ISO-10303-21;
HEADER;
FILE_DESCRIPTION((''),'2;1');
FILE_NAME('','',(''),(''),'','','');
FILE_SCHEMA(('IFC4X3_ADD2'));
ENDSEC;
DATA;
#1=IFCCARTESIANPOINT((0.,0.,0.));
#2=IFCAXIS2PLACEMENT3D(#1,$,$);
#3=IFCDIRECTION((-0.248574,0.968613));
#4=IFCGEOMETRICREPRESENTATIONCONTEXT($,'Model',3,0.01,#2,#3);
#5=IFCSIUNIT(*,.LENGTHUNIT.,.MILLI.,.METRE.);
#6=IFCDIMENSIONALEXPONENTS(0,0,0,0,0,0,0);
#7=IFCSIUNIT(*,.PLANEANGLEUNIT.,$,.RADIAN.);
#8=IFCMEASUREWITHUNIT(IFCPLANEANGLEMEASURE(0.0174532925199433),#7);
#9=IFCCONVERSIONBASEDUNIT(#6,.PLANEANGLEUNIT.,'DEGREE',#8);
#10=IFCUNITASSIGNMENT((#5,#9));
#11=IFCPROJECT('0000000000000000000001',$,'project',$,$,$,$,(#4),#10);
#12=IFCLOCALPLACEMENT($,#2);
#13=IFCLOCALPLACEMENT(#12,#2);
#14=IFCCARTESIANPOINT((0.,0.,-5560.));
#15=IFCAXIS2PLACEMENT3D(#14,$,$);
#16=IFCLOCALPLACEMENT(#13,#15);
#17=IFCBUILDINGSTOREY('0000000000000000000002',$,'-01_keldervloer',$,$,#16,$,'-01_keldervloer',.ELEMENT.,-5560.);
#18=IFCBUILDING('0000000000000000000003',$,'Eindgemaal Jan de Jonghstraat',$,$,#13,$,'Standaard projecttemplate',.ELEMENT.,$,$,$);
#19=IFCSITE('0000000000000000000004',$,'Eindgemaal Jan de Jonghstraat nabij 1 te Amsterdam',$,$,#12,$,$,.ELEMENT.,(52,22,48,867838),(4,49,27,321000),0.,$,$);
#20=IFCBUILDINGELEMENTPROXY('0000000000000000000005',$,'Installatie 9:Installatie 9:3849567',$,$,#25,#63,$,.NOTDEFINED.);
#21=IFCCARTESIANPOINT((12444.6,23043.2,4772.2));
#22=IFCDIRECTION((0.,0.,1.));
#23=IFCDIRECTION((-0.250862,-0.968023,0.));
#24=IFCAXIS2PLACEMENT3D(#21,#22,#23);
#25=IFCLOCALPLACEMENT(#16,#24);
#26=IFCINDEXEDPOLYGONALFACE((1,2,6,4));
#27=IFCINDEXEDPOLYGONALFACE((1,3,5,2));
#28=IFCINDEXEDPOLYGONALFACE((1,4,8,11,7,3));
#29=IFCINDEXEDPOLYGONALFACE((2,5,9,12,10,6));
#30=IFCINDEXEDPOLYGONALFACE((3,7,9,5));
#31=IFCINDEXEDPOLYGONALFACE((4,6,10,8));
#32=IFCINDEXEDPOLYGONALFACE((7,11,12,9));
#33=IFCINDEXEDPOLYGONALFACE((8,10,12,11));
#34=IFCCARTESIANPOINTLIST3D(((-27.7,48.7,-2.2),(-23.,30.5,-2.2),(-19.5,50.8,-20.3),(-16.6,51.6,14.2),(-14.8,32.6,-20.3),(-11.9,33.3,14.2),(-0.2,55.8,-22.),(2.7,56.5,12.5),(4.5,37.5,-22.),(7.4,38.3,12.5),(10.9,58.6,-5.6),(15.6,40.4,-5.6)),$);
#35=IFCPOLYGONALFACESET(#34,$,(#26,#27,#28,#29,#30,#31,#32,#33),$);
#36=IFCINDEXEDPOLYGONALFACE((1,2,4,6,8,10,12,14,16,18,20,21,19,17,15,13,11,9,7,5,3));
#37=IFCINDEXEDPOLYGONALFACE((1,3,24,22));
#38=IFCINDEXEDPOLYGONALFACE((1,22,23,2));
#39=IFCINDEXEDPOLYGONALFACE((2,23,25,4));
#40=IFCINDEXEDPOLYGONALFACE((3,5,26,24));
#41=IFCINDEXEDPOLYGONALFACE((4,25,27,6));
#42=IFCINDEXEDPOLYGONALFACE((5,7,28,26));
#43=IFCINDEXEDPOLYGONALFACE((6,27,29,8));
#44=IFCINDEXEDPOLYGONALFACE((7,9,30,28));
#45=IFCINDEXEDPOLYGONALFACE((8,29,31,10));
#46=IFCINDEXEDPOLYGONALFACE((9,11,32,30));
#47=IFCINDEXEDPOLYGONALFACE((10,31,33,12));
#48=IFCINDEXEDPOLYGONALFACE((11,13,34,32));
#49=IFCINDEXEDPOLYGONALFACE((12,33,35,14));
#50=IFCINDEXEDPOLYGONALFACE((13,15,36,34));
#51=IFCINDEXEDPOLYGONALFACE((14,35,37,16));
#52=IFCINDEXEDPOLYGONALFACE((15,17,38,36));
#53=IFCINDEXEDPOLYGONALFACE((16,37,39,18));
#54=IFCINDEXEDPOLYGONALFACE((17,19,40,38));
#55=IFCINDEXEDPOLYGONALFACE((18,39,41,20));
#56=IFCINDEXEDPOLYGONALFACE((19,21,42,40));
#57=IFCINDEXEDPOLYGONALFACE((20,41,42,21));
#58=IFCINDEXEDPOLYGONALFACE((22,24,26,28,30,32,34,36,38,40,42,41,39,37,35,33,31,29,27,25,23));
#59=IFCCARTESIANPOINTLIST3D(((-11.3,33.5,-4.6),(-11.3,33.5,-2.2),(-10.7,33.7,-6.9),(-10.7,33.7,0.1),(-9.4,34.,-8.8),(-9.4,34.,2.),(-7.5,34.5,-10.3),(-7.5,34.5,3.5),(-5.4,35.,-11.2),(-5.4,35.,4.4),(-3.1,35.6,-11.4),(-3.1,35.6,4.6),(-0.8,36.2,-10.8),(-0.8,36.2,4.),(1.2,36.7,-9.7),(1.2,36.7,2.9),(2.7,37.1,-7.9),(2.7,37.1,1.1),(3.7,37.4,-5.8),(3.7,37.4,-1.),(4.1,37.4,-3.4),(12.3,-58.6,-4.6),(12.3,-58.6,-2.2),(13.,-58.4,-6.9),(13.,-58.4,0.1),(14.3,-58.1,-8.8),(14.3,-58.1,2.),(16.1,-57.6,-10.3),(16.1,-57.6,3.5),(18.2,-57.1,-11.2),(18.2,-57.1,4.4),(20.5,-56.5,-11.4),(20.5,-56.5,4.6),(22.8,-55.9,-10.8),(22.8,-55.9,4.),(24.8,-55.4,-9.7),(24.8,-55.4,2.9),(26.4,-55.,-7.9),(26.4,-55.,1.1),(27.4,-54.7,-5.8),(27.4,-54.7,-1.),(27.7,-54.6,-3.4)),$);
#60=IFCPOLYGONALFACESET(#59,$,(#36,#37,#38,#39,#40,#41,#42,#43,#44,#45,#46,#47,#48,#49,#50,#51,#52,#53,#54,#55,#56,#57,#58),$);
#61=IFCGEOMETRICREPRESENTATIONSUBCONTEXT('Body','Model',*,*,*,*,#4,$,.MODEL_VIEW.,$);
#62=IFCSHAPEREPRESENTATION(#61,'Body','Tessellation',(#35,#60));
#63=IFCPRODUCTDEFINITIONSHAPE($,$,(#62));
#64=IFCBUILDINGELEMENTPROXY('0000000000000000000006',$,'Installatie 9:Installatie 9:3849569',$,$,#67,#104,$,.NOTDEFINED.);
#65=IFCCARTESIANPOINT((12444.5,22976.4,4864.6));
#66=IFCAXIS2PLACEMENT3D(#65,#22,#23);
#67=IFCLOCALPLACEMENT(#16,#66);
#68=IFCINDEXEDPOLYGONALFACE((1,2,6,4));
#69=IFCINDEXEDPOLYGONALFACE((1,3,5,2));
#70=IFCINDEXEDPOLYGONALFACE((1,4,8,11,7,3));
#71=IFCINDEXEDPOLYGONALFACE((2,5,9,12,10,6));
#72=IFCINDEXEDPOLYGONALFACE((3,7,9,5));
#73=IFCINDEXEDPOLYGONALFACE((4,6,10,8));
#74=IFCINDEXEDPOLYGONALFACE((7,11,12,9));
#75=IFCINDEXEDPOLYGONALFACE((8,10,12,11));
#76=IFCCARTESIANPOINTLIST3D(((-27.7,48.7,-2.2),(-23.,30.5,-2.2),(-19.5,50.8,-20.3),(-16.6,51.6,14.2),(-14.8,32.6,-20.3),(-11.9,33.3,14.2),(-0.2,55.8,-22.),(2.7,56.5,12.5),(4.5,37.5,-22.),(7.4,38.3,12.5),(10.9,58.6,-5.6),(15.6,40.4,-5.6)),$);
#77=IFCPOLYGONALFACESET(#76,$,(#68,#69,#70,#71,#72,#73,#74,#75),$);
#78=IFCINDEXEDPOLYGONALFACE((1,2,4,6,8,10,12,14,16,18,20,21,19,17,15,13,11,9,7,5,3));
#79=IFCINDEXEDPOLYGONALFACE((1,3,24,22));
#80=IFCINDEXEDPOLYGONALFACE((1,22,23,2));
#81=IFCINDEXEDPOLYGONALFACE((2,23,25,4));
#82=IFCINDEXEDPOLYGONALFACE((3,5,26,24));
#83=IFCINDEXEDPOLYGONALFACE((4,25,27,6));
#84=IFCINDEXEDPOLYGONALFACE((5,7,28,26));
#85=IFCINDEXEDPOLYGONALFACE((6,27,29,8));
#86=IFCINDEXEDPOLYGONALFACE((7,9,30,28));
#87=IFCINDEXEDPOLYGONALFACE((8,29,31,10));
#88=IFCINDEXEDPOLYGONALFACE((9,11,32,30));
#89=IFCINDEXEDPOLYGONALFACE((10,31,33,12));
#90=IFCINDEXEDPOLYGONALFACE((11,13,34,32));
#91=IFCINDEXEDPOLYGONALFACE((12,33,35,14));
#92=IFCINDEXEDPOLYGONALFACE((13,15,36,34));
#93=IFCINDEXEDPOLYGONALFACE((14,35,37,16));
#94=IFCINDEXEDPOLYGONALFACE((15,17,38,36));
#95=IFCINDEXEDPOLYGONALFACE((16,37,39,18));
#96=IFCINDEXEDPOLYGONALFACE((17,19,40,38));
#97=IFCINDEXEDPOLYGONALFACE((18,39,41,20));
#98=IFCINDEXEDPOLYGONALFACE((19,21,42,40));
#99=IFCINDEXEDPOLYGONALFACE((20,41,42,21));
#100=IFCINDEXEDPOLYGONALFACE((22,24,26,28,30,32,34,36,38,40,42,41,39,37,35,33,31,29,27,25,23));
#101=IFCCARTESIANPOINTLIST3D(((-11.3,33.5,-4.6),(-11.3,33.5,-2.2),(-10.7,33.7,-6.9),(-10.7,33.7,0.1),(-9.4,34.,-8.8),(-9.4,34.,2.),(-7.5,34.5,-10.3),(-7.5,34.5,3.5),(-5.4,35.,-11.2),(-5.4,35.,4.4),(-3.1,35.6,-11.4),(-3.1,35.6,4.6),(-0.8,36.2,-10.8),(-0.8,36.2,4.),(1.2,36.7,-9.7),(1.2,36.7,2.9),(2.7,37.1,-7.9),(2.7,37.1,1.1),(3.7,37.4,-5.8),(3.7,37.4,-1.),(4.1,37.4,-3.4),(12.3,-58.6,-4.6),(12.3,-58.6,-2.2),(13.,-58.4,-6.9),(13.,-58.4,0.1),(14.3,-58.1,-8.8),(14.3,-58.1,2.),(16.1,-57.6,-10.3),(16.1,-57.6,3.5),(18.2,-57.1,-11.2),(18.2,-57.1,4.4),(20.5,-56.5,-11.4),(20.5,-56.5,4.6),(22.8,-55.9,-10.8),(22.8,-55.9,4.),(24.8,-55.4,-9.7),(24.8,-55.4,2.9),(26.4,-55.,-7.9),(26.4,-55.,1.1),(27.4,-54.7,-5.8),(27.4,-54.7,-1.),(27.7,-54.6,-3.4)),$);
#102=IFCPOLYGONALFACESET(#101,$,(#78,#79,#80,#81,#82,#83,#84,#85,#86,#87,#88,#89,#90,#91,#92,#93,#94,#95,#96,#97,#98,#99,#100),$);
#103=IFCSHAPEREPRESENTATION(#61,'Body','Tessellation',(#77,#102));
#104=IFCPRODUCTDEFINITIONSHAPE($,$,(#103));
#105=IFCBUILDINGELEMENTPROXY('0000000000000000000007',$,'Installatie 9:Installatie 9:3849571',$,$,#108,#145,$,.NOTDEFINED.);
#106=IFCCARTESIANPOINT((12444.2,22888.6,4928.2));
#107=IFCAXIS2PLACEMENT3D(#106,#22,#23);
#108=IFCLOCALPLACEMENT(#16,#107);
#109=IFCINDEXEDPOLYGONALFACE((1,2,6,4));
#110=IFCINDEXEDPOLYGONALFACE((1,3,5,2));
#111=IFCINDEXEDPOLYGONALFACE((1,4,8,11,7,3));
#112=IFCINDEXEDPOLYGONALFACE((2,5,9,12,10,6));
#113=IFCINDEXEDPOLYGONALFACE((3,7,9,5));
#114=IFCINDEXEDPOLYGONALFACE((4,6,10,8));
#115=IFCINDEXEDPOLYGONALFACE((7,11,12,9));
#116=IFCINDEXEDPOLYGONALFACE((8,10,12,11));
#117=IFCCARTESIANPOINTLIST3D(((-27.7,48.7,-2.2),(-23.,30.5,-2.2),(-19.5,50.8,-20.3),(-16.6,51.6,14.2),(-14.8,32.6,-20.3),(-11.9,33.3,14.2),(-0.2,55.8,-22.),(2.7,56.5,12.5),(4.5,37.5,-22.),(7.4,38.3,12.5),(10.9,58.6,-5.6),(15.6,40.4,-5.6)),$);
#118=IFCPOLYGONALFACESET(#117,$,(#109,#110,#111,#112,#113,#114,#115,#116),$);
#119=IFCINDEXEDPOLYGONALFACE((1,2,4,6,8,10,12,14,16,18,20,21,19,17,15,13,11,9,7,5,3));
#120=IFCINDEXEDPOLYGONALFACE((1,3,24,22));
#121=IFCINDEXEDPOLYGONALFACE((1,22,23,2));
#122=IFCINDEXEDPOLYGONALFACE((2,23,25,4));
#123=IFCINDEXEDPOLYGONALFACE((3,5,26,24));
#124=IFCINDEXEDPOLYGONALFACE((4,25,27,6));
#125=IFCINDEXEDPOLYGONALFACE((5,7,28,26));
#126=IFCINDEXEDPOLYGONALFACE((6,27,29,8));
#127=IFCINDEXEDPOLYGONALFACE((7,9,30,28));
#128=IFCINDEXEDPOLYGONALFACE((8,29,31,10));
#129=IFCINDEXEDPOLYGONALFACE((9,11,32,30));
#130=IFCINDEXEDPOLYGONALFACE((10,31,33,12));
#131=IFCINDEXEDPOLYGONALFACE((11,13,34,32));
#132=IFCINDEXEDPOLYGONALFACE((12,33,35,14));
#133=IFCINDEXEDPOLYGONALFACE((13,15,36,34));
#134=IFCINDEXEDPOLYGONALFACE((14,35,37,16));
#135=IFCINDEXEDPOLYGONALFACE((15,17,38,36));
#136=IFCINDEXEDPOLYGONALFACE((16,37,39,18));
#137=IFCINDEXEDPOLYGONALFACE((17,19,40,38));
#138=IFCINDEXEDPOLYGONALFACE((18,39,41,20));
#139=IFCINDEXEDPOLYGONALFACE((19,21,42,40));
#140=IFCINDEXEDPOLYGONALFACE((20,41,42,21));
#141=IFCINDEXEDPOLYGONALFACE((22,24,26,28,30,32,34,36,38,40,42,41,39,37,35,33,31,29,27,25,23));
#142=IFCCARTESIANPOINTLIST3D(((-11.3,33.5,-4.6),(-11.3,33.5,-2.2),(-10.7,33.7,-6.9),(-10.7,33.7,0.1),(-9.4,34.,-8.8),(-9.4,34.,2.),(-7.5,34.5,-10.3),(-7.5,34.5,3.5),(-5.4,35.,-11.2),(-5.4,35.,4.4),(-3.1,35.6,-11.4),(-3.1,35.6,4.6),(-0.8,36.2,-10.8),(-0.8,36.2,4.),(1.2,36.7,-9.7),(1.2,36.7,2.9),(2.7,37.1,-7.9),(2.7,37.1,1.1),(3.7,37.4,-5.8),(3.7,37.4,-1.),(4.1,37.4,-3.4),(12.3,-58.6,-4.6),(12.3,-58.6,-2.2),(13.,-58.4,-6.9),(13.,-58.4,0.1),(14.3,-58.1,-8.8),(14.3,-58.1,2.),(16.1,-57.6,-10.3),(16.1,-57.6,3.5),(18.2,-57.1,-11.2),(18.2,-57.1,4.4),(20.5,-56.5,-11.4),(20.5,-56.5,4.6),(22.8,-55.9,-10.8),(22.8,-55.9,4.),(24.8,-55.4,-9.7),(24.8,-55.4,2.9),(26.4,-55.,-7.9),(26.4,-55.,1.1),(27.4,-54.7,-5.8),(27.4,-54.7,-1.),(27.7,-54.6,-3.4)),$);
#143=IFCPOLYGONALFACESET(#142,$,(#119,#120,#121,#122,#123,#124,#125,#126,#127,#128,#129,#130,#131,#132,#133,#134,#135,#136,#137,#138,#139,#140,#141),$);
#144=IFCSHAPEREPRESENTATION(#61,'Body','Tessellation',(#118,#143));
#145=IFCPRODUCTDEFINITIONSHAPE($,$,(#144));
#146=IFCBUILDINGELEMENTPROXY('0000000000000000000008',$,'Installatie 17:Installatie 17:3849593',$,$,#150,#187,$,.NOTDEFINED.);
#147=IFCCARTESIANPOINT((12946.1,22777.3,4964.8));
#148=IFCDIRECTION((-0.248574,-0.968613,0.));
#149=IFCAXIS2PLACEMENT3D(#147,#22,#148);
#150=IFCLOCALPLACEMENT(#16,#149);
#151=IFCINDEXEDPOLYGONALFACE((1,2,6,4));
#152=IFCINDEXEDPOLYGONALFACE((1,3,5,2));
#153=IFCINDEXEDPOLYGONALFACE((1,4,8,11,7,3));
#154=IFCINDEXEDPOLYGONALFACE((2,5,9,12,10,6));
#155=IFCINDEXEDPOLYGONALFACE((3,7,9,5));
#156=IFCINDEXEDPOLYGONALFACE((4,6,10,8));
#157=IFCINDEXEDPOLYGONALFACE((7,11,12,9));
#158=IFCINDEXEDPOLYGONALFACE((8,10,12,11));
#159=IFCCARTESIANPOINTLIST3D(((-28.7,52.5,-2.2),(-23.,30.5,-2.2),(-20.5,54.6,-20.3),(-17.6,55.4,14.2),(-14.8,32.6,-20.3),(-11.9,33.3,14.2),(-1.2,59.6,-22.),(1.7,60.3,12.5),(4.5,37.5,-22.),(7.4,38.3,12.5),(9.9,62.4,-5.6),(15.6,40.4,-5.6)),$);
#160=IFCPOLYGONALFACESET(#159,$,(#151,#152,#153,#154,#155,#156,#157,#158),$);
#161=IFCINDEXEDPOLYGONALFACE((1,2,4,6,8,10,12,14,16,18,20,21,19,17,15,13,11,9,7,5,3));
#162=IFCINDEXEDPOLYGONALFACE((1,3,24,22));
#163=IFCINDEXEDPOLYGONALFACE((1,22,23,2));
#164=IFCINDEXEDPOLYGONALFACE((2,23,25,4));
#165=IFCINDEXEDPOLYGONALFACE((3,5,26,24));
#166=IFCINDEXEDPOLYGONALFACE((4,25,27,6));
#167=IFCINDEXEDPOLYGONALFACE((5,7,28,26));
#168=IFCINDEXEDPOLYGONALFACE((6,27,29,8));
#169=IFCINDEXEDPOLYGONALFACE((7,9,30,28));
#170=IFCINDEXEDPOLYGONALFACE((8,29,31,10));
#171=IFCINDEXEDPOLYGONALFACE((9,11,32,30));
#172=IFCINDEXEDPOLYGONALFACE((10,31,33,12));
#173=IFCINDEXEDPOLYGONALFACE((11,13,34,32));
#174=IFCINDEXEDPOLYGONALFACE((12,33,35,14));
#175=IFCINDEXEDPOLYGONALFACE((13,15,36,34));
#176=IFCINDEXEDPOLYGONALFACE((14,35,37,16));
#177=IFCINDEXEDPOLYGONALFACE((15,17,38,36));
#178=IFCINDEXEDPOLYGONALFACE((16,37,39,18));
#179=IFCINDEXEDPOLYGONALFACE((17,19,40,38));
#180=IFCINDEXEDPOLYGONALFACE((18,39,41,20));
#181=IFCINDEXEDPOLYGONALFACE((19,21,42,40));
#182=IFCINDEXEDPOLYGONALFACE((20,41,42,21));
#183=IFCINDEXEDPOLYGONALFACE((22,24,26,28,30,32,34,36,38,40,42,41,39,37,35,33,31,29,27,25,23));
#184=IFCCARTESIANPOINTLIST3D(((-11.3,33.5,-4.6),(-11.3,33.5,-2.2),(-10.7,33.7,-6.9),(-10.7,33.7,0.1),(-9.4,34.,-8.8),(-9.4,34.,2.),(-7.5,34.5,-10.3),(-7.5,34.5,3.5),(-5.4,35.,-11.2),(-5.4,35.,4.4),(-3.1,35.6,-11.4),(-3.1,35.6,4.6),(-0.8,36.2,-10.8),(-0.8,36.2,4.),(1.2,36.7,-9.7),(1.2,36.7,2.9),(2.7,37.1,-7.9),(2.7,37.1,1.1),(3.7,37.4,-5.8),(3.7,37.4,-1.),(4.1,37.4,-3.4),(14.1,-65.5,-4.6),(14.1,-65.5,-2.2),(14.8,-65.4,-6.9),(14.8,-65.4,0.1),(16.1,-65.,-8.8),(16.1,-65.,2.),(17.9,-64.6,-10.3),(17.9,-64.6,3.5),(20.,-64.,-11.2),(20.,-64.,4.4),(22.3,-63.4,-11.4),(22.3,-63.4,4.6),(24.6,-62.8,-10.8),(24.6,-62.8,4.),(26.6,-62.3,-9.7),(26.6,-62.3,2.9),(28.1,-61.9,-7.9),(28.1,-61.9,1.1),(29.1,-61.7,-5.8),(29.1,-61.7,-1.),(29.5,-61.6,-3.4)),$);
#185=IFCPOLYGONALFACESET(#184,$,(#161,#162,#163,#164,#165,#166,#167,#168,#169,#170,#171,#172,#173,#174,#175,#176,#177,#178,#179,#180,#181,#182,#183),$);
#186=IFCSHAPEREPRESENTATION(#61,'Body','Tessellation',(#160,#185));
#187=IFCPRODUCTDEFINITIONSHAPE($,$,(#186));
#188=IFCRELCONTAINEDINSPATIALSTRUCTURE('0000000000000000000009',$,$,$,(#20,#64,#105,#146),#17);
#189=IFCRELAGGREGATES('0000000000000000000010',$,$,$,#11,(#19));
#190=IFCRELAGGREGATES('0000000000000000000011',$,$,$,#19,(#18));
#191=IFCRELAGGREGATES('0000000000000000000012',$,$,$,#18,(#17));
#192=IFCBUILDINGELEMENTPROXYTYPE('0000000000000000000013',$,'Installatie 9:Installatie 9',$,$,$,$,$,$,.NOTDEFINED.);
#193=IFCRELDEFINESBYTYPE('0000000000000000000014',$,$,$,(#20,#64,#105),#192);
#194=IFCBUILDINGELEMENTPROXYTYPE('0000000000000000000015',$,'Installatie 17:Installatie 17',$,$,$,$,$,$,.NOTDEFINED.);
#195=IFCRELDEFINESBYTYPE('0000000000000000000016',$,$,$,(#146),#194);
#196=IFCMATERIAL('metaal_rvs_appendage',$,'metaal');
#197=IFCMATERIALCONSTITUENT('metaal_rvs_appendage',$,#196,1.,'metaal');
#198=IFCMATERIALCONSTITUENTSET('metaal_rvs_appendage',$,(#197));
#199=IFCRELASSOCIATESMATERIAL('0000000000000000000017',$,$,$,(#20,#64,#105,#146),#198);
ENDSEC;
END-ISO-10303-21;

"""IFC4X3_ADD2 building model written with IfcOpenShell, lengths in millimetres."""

from ifc_helpers import new_model, entity, si_unit, converted_unit, direction, frame, frame_2d, origin, place, context, subcontext, project, spatial, polyline, circle, outline, extrude, source, transform, mapped, material, constituent, constituent_set, type_object, type_shapes, element, save


model = new_model("IFC4X3_ADD2")

# Units and contexts
model_context = context("Model", 3, precision=0.01, world=origin(), true_north=direction((-0.248574, 0.968613)))
body_context = subcontext(model_context, "Body", "Model", "MODEL_VIEW")
ifc_project = project(units=[si_unit("LENGTHUNIT", "METRE", prefix="MILLI"), converted_unit("PLANEANGLEUNIT", "DEGREE", entity("IfcPlaneAngleMeasure", 0.0174532925199433), si_unit("PLANEANGLEUNIT", "RADIAN"), dimensions=[0, 0, 0, 0, 0, 0, 0])], contexts=[model_context])

# Site, building, storey
site_placement = place(None, origin())
site = spatial("IfcSite", under=ifc_project, at=site_placement, Name="Eindgemaal Jan de Jonghstraat nabij 1 te Amsterdam", CompositionType="ELEMENT", RefLatitude=(52, 22, 48, 867838), RefLongitude=(4, 49, 27, 321000), RefElevation=0.0)
building_placement = place(site_placement, origin())
building = spatial("IfcBuilding", under=site, at=building_placement, Name="Eindgemaal Jan de Jonghstraat", LongName="Standaard projecttemplate", CompositionType="ELEMENT")
storey_placement = place(building_placement, frame((0.0, 0.0, -5560.0)))
storey = spatial("IfcBuildingStorey", under=building, at=storey_placement, Name="-01_keldervloer", LongName="-01_keldervloer", CompositionType="ELEMENT", Elevation=-5560.0)

# Building element proxies
ifc_material_1 = material(Name="metaal_rvs_appendage", Category="metaal")
ifc_constituent_1 = constituent(ifc_material_1, Name="metaal_rvs_appendage", Category="metaal", fraction=1.0)
ifc_constituent_set_1 = constituent_set(constituents=[ifc_constituent_1], Name="metaal_rvs_appendage")
building_element_proxy_type_1 = type_object("IfcBuildingElementProxyType", Name="Installatie 9:Installatie 9", PredefinedType="NOTDEFINED")
shared_shape_1 = source(origin(), body_context, "Body", "SweptSolid", [
    extrude(outline(polyline([(-10.0, -17.3), (10.0, -17.3), (20.0, 0.0), (10.0, 17.3), (-10.0, 17.3), (-20.0, 0.0), (-10.0, -17.3)])), frame((-3.7, 35.4, -3.9), z_axis=(-0.248574, 0.968613, 0.0), x_axis=(-0.555573, -0.142576, -0.819152)), (0.0, 0.0, 1.0), 18.8),
    extrude(circle(Radius=8.0, at=frame_2d((0.0, 0.0), x_axis=(1.0, 0.0))), frame((20.0, -56.6, -3.4), z_axis=(-0.248574, 0.968613, 0.0), x_axis=(0.968613, 0.248574, 0.0)), (0.0, 0.0, 1.0), 95.1),
])
type_shapes(building_element_proxy_type_1, [shared_shape_1])
for number, where, z_axis, x_axis, name in (
    (1, (12444.6, 23043.2, 4772.2), (0.0, 0.0, 1.0), (-0.250862, -0.968023, 0.0), "Installatie 9:Installatie 9:3849567"),
    (2, (12444.5, 22976.4, 4864.6), (0.0, 0.0, 1.0), (-0.250862, -0.968023, 0.0), "Installatie 9:Installatie 9:3849569"),
    (3, (12444.2, 22888.6, 4928.2), (0.0, 0.0, 1.0), (-0.250862, -0.968023, 0.0), "Installatie 9:Installatie 9:3849571"),
):
    element("IfcBuildingElementProxy", number, at=place(storey_placement, frame(where, z_axis=z_axis, x_axis=x_axis)), inside=storey, type_object=building_element_proxy_type_1, material=ifc_constituent_set_1, Name=name, PredefinedType="NOTDEFINED", context=body_context, shape_type="MappedRepresentation", body=[
        mapped(shared_shape_1, transform((0.0, 0.0, 0.0), scale=1.0)),
    ])
building_element_proxy_type_2 = type_object("IfcBuildingElementProxyType", Name="Installatie 17:Installatie 17", PredefinedType="NOTDEFINED")
shared_shape_2 = source(origin(), body_context, "Body", "SweptSolid", [
    extrude(outline(polyline([(-10.0, -17.3), (10.0, -17.3), (20.0, 0.0), (10.0, 17.3), (-10.0, 17.3), (-20.0, 0.0), (-10.0, -17.3)])), frame((-3.7, 35.4, -3.9), z_axis=(-0.248574, 0.968613, 0.0), x_axis=(-0.555573, -0.142576, -0.819152)), (0.0, 0.0, 1.0), 22.8),
    extrude(circle(Radius=8.0, at=frame_2d((0.0, 0.0), x_axis=(1.0, 0.0))), frame((21.7, -63.6, -3.4), z_axis=(-0.248574, 0.968613, 0.0), x_axis=(0.968613, 0.248574, 0.0)), (0.0, 0.0, 1.0), 102.2),
])
type_shapes(building_element_proxy_type_2, [shared_shape_2])
for number, where, z_axis, x_axis, name in (
    (4, (12946.1, 22777.3, 4964.8), (0.0, 0.0, 1.0), (-0.248574, -0.968613, 0.0), "Installatie 17:Installatie 17:3849593"),
):
    element("IfcBuildingElementProxy", number, at=place(storey_placement, frame(where, z_axis=z_axis, x_axis=x_axis)), inside=storey, type_object=building_element_proxy_type_2, material=ifc_constituent_set_1, Name=name, PredefinedType="NOTDEFINED", context=body_context, shape_type="MappedRepresentation", body=[
        mapped(shared_shape_2, transform((0.0, 0.0, 0.0), scale=1.0)),
    ])

save(model, "model.ifc")
